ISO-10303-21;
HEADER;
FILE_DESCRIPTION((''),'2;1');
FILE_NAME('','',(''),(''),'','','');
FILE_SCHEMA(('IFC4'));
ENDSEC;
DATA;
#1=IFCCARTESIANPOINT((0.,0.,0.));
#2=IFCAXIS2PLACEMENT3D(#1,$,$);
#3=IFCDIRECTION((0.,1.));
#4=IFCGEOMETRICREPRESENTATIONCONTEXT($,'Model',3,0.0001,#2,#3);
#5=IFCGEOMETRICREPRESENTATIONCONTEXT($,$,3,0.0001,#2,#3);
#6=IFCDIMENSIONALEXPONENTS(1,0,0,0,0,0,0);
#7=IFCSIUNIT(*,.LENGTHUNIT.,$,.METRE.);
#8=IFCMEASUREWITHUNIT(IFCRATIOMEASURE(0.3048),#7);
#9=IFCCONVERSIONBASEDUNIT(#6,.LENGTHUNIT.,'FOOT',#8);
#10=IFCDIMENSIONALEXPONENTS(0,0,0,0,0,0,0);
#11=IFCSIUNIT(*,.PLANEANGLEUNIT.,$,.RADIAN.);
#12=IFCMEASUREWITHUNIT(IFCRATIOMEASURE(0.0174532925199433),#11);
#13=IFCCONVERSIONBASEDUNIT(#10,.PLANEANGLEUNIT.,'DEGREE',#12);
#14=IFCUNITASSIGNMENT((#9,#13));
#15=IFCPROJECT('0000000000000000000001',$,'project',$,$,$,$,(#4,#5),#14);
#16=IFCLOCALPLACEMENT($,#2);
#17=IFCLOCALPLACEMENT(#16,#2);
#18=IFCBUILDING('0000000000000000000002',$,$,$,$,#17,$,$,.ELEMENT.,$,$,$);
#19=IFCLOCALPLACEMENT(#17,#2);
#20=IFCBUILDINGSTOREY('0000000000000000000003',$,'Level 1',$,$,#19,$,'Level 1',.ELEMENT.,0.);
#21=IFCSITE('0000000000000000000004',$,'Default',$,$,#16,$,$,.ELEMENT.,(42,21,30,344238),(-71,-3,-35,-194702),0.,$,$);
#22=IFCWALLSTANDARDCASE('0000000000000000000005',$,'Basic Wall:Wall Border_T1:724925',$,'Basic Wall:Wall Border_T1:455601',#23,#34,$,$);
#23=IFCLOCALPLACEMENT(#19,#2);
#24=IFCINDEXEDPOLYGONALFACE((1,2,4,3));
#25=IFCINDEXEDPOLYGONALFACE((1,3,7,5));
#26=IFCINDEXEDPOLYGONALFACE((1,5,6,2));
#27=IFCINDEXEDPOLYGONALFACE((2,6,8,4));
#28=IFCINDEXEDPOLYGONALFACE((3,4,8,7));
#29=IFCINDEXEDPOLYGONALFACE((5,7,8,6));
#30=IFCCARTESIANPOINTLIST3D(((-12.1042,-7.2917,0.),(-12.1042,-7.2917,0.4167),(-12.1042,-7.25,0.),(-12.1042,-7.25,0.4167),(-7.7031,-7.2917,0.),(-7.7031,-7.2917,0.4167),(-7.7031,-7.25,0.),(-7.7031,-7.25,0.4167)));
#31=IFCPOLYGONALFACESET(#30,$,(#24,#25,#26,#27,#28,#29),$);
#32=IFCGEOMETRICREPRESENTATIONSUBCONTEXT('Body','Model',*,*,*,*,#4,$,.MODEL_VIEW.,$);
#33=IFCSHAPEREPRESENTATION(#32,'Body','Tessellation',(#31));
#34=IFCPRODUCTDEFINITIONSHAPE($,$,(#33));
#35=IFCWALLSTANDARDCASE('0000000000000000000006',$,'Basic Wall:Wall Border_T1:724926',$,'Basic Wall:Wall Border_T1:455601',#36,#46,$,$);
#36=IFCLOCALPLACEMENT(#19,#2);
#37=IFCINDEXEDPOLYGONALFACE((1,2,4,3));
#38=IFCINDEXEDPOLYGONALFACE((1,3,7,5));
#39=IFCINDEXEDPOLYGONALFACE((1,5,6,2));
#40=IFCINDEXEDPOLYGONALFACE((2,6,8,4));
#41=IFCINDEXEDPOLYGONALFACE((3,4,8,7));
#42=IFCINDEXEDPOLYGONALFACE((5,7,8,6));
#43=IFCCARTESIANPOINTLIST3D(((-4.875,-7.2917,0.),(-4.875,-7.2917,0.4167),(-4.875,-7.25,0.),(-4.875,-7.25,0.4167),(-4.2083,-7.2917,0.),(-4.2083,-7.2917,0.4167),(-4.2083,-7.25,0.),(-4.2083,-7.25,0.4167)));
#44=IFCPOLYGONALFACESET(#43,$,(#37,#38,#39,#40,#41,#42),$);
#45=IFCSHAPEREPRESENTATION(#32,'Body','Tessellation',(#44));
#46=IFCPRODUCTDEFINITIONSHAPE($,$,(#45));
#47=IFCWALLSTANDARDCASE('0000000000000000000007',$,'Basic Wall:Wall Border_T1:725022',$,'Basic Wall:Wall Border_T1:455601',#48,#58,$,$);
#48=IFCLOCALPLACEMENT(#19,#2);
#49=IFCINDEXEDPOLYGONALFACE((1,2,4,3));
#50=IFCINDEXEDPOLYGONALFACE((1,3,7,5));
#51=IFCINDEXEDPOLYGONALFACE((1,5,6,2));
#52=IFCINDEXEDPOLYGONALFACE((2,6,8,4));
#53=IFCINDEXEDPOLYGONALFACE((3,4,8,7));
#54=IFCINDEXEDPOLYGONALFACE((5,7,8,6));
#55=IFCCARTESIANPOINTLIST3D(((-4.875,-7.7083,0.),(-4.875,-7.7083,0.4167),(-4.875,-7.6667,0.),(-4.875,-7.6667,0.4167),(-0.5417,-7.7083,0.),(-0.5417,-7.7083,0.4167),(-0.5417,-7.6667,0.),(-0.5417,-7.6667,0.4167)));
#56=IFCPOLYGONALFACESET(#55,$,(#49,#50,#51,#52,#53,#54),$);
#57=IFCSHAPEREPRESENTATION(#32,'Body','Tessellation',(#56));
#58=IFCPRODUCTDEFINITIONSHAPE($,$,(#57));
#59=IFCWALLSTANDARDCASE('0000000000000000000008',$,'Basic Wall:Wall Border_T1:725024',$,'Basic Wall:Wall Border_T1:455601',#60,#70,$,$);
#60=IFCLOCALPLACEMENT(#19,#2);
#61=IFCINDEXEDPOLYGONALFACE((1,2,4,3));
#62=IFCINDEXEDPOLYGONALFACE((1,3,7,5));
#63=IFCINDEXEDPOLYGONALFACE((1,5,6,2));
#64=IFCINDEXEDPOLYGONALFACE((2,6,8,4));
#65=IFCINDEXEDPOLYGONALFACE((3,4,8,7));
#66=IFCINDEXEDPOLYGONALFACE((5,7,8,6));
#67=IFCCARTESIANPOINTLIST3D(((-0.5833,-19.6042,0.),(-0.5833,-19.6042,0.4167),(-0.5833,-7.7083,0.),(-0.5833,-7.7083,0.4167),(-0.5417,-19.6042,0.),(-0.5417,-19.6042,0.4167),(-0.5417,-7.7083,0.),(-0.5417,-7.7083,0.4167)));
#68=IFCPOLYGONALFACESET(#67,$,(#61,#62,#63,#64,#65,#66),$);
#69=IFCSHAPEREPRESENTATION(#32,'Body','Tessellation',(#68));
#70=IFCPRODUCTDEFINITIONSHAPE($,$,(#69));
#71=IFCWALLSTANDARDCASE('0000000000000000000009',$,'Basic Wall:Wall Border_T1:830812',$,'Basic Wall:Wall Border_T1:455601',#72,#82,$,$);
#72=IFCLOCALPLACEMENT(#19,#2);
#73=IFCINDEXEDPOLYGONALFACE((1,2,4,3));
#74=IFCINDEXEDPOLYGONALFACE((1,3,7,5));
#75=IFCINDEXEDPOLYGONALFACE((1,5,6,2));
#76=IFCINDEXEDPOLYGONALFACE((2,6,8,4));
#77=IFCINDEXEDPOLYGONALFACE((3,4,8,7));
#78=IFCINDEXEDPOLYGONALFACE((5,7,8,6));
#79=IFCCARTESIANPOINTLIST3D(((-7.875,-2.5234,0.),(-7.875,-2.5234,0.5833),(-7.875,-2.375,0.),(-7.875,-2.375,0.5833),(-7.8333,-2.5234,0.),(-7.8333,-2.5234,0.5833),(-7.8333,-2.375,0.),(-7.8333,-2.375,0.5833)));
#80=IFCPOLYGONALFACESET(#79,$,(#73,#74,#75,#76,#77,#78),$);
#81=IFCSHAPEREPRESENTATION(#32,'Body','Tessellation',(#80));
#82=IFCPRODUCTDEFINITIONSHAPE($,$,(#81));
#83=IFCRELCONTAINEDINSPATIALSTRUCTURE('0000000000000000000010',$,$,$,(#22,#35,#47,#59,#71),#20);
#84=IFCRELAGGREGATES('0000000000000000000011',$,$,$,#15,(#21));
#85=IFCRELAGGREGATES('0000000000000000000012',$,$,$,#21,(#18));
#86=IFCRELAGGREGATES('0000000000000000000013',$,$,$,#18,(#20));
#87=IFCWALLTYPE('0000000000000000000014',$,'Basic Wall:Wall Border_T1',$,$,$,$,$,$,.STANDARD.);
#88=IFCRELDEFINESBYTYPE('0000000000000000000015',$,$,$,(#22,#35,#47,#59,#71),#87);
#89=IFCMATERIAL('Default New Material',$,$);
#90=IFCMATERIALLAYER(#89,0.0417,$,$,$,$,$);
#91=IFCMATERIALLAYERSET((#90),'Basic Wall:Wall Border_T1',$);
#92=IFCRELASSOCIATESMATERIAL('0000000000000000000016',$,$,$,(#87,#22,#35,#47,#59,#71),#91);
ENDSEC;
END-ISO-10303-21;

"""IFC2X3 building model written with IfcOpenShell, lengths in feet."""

from ifc_helpers import new_model, entity, si_unit, converted_unit, direction, frame, frame_2d, origin, place, context, subcontext, project, spatial, rectangle, extrude, material, layer, layer_set, layer_usage, type_object, element, save


model = new_model("IFC2X3")

# Units and contexts
model_context = context("Model", 3, precision=0.0001, world=origin(), true_north=direction((0.0, 1.0)))
context_of_model = context(None, 3, precision=0.0001, world=origin(), true_north=direction((0.0, 1.0)))
body_context = subcontext(model_context, "Body", "Model", "MODEL_VIEW")
ifc_project = project(units=[converted_unit("LENGTHUNIT", "FOOT", entity("IfcRatioMeasure", 0.3048), si_unit("LENGTHUNIT", "METRE"), dimensions=[1, 0, 0, 0, 0, 0, 0]), converted_unit("PLANEANGLEUNIT", "DEGREE", entity("IfcRatioMeasure", 0.0174532925199433), si_unit("PLANEANGLEUNIT", "RADIAN"), dimensions=[0, 0, 0, 0, 0, 0, 0])], contexts=[model_context, context_of_model])

# Site, building, storey
site_placement = place(None, origin())
site = spatial("IfcSite", under=ifc_project, at=site_placement, Name="Default", CompositionType="ELEMENT", RefLatitude=(42, 21, 30, 344238), RefLongitude=(-71, -3, -35, -194702), RefElevation=0.0)
building_placement = place(site_placement, origin())
building = spatial("IfcBuilding", under=site, at=building_placement, CompositionType="ELEMENT")
storey_placement = place(building_placement, origin())
storey = spatial("IfcBuildingStorey", under=building, at=storey_placement, Name="Level 1", LongName="Level 1", CompositionType="ELEMENT", Elevation=0.0)

# Shared definitions
ifc_material_1 = material(Name="Default New Material")

# Walls
ifc_layer_1 = layer(ifc_material_1, 0.0417)
ifc_layer_set_1 = layer_set([ifc_layer_1], Name="Basic Wall:Wall Border_T1")
ifc_layer_usage_1 = layer_usage(ifc_layer_set_1, "AXIS2", "POSITIVE", -0.0208)
wall_type_1 = type_object("IfcWallType", Name="Basic Wall:Wall Border_T1", PredefinedType="STANDARD", material=ifc_layer_set_1)
wall_1_placement = place(storey_placement, frame((-7.7031, -7.2708, 0.0), z_axis=(0.0, 0.0, 1.0), x_axis=(-1.0, 0.0, 0.0)))
element("IfcWallStandardCase", 1, at=wall_1_placement, inside=storey, type_object=wall_type_1, material=ifc_layer_usage_1, Name="Basic Wall:Wall Border_T1:724925", ObjectType="Basic Wall:Wall Border_T1:455601", context=body_context, shape_type="SweptSolid", body=[
    extrude(rectangle(XDim=4.4011, YDim=0.0417, at=frame_2d((2.2005, 0.0), x_axis=(-1.0, 0.0))), origin(), (0.0, 0.0, 1.0), 0.4167),
])
ifc_layer_usage_2 = layer_usage(ifc_layer_set_1, "AXIS2", "POSITIVE", -0.0208)
wall_2_placement = place(storey_placement, frame((-4.2083, -7.2708, 0.0), z_axis=(0.0, 0.0, 1.0), x_axis=(-1.0, 0.0, 0.0)))
element("IfcWallStandardCase", 2, at=wall_2_placement, inside=storey, type_object=wall_type_1, material=ifc_layer_usage_2, Name="Basic Wall:Wall Border_T1:724926", ObjectType="Basic Wall:Wall Border_T1:455601", context=body_context, shape_type="SweptSolid", body=[
    extrude(rectangle(XDim=0.6667, YDim=0.0417, at=frame_2d((0.3333, 0.0), x_axis=(-1.0, 0.0))), origin(), (0.0, 0.0, 1.0), 0.4167),
])
ifc_layer_usage_3 = layer_usage(ifc_layer_set_1, "AXIS2", "POSITIVE", -0.0208)
wall_3_placement = place(storey_placement, frame((-4.875, -7.6875, 0.0)))
element("IfcWallStandardCase", 3, at=wall_3_placement, inside=storey, type_object=wall_type_1, material=ifc_layer_usage_3, Name="Basic Wall:Wall Border_T1:725022", ObjectType="Basic Wall:Wall Border_T1:455601", context=body_context, shape_type="SweptSolid", body=[
    extrude(rectangle(XDim=4.3333, YDim=0.0417, at=frame_2d((2.1667, 0.0), x_axis=(-1.0, 0.0))), origin(), (0.0, 0.0, 1.0), 0.4167),
])
ifc_layer_usage_4 = layer_usage(ifc_layer_set_1, "AXIS2", "POSITIVE", -0.0208)
wall_4_placement = place(storey_placement, frame((-0.5625, -7.7083, 0.0), z_axis=(0.0, 0.0, 1.0), x_axis=(0.0, -1.0, 0.0)))
element("IfcWallStandardCase", 4, at=wall_4_placement, inside=storey, type_object=wall_type_1, material=ifc_layer_usage_4, Name="Basic Wall:Wall Border_T1:725024", ObjectType="Basic Wall:Wall Border_T1:455601", context=body_context, shape_type="SweptSolid", body=[
    extrude(rectangle(XDim=11.8958, YDim=0.0417, at=frame_2d((5.9479, 0.0), x_axis=(-1.0, 0.0))), origin(), (0.0, 0.0, 1.0), 0.4167),
])
ifc_layer_usage_5 = layer_usage(ifc_layer_set_1, "AXIS2", "NEGATIVE", 0.0208)
wall_5_placement = place(storey_placement, frame((-7.8542, -2.375, 0.0), z_axis=(0.0, 0.0, 1.0), x_axis=(0.0, -1.0, 0.0)))
element("IfcWallStandardCase", 5, at=wall_5_placement, inside=storey, type_object=wall_type_1, material=ifc_layer_usage_5, Name="Basic Wall:Wall Border_T1:830812", ObjectType="Basic Wall:Wall Border_T1:455601", context=body_context, shape_type="SweptSolid", body=[
    extrude(rectangle(XDim=0.1484, YDim=0.0417, at=frame_2d((0.0742, 0.0), x_axis=(-1.0, 0.0))), origin(), (0.0, 0.0, 1.0), 0.5833),
])

save(model, "model.ifc")
